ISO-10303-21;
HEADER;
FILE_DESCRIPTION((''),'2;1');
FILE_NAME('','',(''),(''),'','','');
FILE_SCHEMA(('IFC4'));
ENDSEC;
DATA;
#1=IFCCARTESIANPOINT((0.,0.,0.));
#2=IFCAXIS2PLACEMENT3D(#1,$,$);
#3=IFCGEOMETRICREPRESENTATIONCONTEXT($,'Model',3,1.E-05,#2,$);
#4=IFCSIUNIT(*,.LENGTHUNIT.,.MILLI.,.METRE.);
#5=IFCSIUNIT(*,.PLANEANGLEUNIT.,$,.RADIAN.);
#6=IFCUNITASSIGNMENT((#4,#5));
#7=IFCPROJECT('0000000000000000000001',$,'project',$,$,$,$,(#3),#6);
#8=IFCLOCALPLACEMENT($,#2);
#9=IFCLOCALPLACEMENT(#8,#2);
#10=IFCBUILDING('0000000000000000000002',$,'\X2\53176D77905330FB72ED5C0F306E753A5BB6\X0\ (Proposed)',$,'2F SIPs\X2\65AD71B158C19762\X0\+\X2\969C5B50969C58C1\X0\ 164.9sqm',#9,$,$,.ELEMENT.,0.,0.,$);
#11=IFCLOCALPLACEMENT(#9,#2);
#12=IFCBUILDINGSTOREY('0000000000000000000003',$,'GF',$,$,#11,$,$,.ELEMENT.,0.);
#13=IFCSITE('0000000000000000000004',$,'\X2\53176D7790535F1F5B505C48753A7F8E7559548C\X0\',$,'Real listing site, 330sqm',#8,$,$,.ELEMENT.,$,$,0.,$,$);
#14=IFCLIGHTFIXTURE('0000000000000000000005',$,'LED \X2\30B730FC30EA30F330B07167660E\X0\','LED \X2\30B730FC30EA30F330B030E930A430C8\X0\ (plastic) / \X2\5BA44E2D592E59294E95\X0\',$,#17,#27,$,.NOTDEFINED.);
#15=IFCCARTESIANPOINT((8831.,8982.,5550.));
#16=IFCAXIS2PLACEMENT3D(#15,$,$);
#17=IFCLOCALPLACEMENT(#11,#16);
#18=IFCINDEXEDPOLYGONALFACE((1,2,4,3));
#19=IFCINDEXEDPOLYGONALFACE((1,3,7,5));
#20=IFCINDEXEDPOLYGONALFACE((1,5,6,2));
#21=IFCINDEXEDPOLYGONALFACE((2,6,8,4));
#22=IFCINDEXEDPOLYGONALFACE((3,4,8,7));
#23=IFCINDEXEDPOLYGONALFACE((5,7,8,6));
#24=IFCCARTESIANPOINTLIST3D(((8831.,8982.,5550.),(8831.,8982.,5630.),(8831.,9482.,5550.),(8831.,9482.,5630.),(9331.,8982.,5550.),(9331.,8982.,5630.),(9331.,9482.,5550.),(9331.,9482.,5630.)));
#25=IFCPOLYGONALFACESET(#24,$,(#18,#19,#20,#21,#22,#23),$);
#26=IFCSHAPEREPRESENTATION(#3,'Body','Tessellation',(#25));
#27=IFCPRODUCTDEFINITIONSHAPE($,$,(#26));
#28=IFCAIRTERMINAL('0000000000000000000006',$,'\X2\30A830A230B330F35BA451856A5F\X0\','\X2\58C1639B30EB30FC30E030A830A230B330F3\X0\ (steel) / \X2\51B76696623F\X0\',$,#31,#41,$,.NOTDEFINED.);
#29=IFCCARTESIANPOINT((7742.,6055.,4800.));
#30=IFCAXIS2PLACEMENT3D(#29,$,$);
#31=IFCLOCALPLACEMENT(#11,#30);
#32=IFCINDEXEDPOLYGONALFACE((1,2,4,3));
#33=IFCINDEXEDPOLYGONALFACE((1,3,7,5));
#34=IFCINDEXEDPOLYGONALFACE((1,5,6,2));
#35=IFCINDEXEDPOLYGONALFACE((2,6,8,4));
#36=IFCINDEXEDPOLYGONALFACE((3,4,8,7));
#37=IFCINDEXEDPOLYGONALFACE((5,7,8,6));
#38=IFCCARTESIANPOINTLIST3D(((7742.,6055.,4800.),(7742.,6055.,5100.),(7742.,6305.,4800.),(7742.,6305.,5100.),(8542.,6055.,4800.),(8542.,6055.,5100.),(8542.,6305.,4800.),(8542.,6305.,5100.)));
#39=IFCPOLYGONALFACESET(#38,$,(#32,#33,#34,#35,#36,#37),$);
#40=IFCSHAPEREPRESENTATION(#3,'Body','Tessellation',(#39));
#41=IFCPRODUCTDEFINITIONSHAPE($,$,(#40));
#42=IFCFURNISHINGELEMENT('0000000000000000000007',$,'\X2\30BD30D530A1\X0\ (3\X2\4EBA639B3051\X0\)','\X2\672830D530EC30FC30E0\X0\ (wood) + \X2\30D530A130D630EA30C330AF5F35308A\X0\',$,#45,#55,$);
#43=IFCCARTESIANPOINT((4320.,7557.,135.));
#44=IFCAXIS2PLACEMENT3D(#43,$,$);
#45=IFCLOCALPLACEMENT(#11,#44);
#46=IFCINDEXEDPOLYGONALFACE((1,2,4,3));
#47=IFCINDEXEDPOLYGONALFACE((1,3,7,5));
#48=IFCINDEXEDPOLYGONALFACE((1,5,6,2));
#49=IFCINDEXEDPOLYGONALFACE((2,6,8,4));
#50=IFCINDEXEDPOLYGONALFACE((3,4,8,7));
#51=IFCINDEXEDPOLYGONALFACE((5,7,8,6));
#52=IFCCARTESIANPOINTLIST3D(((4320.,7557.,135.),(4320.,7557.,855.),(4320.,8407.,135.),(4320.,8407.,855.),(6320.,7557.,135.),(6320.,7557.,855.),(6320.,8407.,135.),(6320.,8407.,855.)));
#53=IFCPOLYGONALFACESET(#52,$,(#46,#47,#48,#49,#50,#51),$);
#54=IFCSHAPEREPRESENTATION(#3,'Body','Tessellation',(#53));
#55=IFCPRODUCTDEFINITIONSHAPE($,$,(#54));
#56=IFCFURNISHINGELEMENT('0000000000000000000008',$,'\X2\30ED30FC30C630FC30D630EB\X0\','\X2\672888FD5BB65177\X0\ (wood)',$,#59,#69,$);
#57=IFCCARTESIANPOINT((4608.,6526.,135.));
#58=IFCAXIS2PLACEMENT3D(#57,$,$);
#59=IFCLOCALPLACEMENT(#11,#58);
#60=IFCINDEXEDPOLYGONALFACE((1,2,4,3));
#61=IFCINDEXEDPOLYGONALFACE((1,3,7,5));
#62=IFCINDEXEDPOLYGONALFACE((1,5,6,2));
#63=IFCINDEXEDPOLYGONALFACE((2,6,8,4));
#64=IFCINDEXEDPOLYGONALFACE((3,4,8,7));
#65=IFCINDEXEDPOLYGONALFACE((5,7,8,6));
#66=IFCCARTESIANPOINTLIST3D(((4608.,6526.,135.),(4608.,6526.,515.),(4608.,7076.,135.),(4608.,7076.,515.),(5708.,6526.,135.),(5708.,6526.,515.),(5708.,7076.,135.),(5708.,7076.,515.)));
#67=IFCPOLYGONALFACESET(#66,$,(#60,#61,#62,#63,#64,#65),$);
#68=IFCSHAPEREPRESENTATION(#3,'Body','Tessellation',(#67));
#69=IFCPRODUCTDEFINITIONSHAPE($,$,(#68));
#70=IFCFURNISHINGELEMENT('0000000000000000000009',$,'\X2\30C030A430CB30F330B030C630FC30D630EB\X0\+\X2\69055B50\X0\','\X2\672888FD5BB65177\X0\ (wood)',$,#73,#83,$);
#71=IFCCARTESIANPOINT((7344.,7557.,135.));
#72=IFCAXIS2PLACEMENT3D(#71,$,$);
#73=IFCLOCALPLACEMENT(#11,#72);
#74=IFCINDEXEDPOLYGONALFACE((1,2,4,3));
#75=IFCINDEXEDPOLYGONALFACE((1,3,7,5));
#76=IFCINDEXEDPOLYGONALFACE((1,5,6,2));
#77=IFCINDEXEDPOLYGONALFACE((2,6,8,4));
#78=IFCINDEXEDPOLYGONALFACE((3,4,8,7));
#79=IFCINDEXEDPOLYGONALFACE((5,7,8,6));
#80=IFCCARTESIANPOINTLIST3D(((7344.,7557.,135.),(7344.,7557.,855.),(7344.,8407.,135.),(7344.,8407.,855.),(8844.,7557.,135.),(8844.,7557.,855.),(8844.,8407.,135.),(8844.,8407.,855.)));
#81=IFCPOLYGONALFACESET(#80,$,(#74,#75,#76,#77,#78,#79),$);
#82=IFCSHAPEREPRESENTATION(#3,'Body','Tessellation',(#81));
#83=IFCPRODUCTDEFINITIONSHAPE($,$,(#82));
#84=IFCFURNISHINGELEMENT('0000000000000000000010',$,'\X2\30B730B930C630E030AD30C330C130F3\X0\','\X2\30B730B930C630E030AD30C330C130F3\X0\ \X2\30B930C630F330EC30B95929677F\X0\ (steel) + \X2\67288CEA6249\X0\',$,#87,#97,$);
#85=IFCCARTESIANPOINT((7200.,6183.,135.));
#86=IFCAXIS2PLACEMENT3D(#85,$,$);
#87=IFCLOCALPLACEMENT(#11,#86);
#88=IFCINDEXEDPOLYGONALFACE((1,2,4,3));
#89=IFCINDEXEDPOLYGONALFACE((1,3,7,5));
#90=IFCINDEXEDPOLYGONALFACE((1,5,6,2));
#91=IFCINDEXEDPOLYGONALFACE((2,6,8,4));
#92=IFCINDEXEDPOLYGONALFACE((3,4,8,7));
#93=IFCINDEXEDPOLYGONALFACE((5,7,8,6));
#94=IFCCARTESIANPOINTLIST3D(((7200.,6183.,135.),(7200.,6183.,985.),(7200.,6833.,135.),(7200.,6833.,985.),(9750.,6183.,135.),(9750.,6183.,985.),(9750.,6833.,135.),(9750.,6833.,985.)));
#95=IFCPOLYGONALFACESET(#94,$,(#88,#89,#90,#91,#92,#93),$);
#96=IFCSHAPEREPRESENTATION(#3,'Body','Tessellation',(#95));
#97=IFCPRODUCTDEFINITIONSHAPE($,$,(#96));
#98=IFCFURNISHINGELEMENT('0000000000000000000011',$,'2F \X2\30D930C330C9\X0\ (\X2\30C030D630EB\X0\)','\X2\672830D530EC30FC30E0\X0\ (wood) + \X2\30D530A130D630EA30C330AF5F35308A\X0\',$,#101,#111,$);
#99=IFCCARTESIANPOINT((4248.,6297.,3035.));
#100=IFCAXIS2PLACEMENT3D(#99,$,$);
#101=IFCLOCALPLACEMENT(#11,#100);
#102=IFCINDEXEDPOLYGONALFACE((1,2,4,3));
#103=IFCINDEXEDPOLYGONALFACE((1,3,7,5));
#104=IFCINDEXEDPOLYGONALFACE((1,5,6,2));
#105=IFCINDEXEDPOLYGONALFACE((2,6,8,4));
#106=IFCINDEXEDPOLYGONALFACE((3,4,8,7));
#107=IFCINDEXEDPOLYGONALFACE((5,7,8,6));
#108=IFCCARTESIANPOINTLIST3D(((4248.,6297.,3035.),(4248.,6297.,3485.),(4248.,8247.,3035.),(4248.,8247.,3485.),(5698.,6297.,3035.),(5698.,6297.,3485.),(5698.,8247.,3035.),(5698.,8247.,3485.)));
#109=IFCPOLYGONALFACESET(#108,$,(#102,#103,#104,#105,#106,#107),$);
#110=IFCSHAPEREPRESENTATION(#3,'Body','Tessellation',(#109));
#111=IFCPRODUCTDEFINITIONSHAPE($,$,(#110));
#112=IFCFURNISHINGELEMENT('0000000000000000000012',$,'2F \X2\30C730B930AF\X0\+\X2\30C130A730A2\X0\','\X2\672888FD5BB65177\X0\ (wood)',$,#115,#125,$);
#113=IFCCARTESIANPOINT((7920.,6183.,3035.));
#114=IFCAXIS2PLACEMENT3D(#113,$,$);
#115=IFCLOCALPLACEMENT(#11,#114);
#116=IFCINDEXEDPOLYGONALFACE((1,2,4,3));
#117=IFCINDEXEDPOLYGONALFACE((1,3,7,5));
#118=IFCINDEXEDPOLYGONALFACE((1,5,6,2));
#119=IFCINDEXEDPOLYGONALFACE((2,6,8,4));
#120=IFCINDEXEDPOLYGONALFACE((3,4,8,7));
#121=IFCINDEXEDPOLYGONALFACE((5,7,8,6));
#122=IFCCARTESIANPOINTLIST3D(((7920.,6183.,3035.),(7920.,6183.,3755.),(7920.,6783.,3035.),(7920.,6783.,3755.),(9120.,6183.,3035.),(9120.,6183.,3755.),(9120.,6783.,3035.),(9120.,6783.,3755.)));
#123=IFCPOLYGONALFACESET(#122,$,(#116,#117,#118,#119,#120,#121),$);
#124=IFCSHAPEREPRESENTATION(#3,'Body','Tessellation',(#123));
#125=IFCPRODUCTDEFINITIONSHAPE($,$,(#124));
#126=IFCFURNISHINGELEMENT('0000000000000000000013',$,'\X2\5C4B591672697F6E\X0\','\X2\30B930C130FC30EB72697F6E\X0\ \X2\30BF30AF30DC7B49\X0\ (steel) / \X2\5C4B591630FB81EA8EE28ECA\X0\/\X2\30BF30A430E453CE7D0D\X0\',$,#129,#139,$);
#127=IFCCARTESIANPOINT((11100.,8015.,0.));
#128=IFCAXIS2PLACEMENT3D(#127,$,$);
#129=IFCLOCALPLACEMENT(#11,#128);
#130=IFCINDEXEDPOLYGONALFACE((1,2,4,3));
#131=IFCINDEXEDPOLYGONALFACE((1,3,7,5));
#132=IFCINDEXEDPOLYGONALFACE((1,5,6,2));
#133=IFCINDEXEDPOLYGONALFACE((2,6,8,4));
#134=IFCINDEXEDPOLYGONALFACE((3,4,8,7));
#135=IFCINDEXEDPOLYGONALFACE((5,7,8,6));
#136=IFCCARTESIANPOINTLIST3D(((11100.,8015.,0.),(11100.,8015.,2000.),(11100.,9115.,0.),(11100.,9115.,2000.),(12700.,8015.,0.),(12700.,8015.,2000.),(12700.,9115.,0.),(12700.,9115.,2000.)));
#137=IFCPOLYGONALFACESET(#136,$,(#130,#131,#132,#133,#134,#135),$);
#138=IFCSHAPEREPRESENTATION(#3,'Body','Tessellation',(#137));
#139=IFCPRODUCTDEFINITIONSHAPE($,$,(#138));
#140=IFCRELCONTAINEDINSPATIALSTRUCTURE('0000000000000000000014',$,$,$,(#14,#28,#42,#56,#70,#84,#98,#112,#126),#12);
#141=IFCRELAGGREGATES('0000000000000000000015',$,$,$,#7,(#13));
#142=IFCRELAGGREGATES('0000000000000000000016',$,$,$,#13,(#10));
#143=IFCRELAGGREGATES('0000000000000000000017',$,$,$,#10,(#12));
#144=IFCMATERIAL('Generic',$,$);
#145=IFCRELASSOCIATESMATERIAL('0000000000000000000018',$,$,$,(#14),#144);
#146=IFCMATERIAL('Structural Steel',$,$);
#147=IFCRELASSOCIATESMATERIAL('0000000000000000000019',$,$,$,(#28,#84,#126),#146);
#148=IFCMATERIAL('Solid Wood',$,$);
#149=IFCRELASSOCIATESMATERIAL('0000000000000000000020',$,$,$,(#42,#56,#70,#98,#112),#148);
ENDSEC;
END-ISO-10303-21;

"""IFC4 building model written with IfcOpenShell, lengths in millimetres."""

from ifc_helpers import new_model, si_unit, frame, frame_2d, origin, place, context, project, spatial, rectangle, extrude, material, element, save


model = new_model("IFC4")

# Units and contexts
model_context = context("Model", 3, precision=1e-05, world=origin())
ifc_project = project(units=[si_unit("LENGTHUNIT", "METRE", prefix="MILLI"), si_unit("PLANEANGLEUNIT", "RADIAN")], contexts=[model_context])

# Site, building, storey
site_placement = place(None, origin())
site = spatial("IfcSite", under=ifc_project, at=site_placement, Name="北海道弟子屈町美留和", ObjectType="Real listing site, 330sqm", CompositionType="ELEMENT", RefElevation=0.0)
building_placement = place(site_placement, origin())
building = spatial("IfcBuilding", under=site, at=building_placement, Name="北海道・狭小の町家 (Proposed)", ObjectType="2F SIPs断熱壁面+障子障壁 164.9sqm", CompositionType="ELEMENT", ElevationOfRefHeight=0.0, ElevationOfTerrain=0.0)
storey_placement = place(building_placement, origin())
storey = spatial("IfcBuildingStorey", under=building, at=storey_placement, Name="GF", CompositionType="ELEMENT", Elevation=0.0)

# Shared definitions
ifc_material_1 = material(Name="Solid Wood")

# Shared definitions
ifc_material_2 = material(Name="Generic")

# Shared definitions
ifc_material_3 = material(Name="Structural Steel")

# Light fixture
light_fixture_placement = place(storey_placement, frame((8831.0, 8982.0, 5550.0)))
element("IfcLightFixture", 1, at=light_fixture_placement, inside=storey, material=ifc_material_2, Name="LED シーリング照明", Description="LED シーリングライト (plastic) / 室中央天井", PredefinedType="NOTDEFINED", context=model_context, shape_type="SweptSolid", body=[
    extrude(rectangle(XDim=500.0, YDim=500.0, at=frame_2d((250.0, 250.0))), frame((8831.0, 8982.0, 5550.0)), (0.0, 0.0, 1.0), 80.0),
])

# Air terminal
air_terminal_1_placement = place(storey_placement, frame((7742.0, 6055.0, 4800.0)))
element("IfcAirTerminal", 2, at=air_terminal_1_placement, inside=storey, material=ifc_material_3, Name="エアコン室内機", Description="壁掛ルームエアコン (steel) / 冷暖房", PredefinedType="NOTDEFINED", context=model_context, shape_type="SweptSolid", body=[
    extrude(rectangle(XDim=800.0, YDim=250.0, at=frame_2d((400.0, 125.0))), frame((7742.0, 6055.0, 4800.0)), (0.0, 0.0, 1.0), 300.0),
])

# Furnishing elements
furnishing_1_placement = place(storey_placement, frame((4320.0, 7557.0, 135.0)))
element("IfcFurnishingElement", 3, at=furnishing_1_placement, inside=storey, material=ifc_material_1, Name="ソファ (3人掛け)", Description="木フレーム (wood) + ファブリック張り", context=model_context, shape_type="SweptSolid", body=[
    extrude(rectangle(XDim=2000.0, YDim=850.0, at=frame_2d((1000.0, 425.0))), frame((4320.0, 7557.0, 135.0)), (0.0, 0.0, 1.0), 720.0),
])
furnishing_2_placement = place(storey_placement, frame((4608.0, 6526.0, 135.0)))
element("IfcFurnishingElement", 4, at=furnishing_2_placement, inside=storey, material=ifc_material_1, Name="ローテーブル", Description="木製家具 (wood)", context=model_context, shape_type="SweptSolid", body=[
    extrude(rectangle(XDim=1100.0, YDim=550.0, at=frame_2d((550.0, 275.0))), frame((4608.0, 6526.0, 135.0)), (0.0, 0.0, 1.0), 380.0),
])
furnishing_3_placement = place(storey_placement, frame((7344.0, 7557.0, 135.0)))
element("IfcFurnishingElement", 5, at=furnishing_3_placement, inside=storey, material=ifc_material_1, Name="ダイニングテーブル+椅子", Description="木製家具 (wood)", context=model_context, shape_type="SweptSolid", body=[
    extrude(rectangle(XDim=1500.0, YDim=850.0, at=frame_2d((750.0, 425.0))), frame((7344.0, 7557.0, 135.0)), (0.0, 0.0, 1.0), 720.0),
])
furnishing_4_placement = place(storey_placement, frame((7200.0, 6183.0, 135.0)))
element("IfcFurnishingElement", 6, at=furnishing_4_placement, inside=storey, material=ifc_material_3, Name="システムキッチン", Description="システムキッチン ステンレス天板 (steel) + 木質扉", context=model_context, shape_type="SweptSolid", body=[
    extrude(rectangle(XDim=2550.0, YDim=650.0, at=frame_2d((1275.0, 325.0))), frame((7200.0, 6183.0, 135.0)), (0.0, 0.0, 1.0), 850.0),
])
furnishing_5_placement = place(storey_placement, frame((4248.0, 6297.0, 3035.0)))
element("IfcFurnishingElement", 7, at=furnishing_5_placement, inside=storey, material=ifc_material_1, Name="2F ベッド (ダブル)", Description="木フレーム (wood) + ファブリック張り", context=model_context, shape_type="SweptSolid", body=[
    extrude(rectangle(XDim=1450.0, YDim=1950.0, at=frame_2d((725.0, 975.0))), frame((4248.0, 6297.0, 3035.0)), (0.0, 0.0, 1.0), 450.0),
])
furnishing_6_placement = place(storey_placement, frame((7920.0, 6183.0, 3035.0)))
element("IfcFurnishingElement", 8, at=furnishing_6_placement, inside=storey, material=ifc_material_1, Name="2F デスク+チェア", Description="木製家具 (wood)", context=model_context, shape_type="SweptSolid", body=[
    extrude(rectangle(XDim=1200.0, YDim=600.0, at=frame_2d((600.0, 300.0))), frame((7920.0, 6183.0, 3035.0)), (0.0, 0.0, 1.0), 720.0),
])
furnishing_7_placement = place(storey_placement, frame((11100.0, 8015.0, 0.0)))
element("IfcFurnishingElement", 9, at=furnishing_7_placement, inside=storey, material=ifc_material_3, Name="屋外物置", Description="スチール物置 タクボ等 (steel) / 屋外・自転車/タイヤ収納", context=model_context, shape_type="SweptSolid", body=[
    extrude(rectangle(XDim=1600.0, YDim=1100.0, at=frame_2d((800.0, 550.0))), frame((11100.0, 8015.0, 0.0)), (0.0, 0.0, 1.0), 2000.0),
])

save(model, "model.ifc")
